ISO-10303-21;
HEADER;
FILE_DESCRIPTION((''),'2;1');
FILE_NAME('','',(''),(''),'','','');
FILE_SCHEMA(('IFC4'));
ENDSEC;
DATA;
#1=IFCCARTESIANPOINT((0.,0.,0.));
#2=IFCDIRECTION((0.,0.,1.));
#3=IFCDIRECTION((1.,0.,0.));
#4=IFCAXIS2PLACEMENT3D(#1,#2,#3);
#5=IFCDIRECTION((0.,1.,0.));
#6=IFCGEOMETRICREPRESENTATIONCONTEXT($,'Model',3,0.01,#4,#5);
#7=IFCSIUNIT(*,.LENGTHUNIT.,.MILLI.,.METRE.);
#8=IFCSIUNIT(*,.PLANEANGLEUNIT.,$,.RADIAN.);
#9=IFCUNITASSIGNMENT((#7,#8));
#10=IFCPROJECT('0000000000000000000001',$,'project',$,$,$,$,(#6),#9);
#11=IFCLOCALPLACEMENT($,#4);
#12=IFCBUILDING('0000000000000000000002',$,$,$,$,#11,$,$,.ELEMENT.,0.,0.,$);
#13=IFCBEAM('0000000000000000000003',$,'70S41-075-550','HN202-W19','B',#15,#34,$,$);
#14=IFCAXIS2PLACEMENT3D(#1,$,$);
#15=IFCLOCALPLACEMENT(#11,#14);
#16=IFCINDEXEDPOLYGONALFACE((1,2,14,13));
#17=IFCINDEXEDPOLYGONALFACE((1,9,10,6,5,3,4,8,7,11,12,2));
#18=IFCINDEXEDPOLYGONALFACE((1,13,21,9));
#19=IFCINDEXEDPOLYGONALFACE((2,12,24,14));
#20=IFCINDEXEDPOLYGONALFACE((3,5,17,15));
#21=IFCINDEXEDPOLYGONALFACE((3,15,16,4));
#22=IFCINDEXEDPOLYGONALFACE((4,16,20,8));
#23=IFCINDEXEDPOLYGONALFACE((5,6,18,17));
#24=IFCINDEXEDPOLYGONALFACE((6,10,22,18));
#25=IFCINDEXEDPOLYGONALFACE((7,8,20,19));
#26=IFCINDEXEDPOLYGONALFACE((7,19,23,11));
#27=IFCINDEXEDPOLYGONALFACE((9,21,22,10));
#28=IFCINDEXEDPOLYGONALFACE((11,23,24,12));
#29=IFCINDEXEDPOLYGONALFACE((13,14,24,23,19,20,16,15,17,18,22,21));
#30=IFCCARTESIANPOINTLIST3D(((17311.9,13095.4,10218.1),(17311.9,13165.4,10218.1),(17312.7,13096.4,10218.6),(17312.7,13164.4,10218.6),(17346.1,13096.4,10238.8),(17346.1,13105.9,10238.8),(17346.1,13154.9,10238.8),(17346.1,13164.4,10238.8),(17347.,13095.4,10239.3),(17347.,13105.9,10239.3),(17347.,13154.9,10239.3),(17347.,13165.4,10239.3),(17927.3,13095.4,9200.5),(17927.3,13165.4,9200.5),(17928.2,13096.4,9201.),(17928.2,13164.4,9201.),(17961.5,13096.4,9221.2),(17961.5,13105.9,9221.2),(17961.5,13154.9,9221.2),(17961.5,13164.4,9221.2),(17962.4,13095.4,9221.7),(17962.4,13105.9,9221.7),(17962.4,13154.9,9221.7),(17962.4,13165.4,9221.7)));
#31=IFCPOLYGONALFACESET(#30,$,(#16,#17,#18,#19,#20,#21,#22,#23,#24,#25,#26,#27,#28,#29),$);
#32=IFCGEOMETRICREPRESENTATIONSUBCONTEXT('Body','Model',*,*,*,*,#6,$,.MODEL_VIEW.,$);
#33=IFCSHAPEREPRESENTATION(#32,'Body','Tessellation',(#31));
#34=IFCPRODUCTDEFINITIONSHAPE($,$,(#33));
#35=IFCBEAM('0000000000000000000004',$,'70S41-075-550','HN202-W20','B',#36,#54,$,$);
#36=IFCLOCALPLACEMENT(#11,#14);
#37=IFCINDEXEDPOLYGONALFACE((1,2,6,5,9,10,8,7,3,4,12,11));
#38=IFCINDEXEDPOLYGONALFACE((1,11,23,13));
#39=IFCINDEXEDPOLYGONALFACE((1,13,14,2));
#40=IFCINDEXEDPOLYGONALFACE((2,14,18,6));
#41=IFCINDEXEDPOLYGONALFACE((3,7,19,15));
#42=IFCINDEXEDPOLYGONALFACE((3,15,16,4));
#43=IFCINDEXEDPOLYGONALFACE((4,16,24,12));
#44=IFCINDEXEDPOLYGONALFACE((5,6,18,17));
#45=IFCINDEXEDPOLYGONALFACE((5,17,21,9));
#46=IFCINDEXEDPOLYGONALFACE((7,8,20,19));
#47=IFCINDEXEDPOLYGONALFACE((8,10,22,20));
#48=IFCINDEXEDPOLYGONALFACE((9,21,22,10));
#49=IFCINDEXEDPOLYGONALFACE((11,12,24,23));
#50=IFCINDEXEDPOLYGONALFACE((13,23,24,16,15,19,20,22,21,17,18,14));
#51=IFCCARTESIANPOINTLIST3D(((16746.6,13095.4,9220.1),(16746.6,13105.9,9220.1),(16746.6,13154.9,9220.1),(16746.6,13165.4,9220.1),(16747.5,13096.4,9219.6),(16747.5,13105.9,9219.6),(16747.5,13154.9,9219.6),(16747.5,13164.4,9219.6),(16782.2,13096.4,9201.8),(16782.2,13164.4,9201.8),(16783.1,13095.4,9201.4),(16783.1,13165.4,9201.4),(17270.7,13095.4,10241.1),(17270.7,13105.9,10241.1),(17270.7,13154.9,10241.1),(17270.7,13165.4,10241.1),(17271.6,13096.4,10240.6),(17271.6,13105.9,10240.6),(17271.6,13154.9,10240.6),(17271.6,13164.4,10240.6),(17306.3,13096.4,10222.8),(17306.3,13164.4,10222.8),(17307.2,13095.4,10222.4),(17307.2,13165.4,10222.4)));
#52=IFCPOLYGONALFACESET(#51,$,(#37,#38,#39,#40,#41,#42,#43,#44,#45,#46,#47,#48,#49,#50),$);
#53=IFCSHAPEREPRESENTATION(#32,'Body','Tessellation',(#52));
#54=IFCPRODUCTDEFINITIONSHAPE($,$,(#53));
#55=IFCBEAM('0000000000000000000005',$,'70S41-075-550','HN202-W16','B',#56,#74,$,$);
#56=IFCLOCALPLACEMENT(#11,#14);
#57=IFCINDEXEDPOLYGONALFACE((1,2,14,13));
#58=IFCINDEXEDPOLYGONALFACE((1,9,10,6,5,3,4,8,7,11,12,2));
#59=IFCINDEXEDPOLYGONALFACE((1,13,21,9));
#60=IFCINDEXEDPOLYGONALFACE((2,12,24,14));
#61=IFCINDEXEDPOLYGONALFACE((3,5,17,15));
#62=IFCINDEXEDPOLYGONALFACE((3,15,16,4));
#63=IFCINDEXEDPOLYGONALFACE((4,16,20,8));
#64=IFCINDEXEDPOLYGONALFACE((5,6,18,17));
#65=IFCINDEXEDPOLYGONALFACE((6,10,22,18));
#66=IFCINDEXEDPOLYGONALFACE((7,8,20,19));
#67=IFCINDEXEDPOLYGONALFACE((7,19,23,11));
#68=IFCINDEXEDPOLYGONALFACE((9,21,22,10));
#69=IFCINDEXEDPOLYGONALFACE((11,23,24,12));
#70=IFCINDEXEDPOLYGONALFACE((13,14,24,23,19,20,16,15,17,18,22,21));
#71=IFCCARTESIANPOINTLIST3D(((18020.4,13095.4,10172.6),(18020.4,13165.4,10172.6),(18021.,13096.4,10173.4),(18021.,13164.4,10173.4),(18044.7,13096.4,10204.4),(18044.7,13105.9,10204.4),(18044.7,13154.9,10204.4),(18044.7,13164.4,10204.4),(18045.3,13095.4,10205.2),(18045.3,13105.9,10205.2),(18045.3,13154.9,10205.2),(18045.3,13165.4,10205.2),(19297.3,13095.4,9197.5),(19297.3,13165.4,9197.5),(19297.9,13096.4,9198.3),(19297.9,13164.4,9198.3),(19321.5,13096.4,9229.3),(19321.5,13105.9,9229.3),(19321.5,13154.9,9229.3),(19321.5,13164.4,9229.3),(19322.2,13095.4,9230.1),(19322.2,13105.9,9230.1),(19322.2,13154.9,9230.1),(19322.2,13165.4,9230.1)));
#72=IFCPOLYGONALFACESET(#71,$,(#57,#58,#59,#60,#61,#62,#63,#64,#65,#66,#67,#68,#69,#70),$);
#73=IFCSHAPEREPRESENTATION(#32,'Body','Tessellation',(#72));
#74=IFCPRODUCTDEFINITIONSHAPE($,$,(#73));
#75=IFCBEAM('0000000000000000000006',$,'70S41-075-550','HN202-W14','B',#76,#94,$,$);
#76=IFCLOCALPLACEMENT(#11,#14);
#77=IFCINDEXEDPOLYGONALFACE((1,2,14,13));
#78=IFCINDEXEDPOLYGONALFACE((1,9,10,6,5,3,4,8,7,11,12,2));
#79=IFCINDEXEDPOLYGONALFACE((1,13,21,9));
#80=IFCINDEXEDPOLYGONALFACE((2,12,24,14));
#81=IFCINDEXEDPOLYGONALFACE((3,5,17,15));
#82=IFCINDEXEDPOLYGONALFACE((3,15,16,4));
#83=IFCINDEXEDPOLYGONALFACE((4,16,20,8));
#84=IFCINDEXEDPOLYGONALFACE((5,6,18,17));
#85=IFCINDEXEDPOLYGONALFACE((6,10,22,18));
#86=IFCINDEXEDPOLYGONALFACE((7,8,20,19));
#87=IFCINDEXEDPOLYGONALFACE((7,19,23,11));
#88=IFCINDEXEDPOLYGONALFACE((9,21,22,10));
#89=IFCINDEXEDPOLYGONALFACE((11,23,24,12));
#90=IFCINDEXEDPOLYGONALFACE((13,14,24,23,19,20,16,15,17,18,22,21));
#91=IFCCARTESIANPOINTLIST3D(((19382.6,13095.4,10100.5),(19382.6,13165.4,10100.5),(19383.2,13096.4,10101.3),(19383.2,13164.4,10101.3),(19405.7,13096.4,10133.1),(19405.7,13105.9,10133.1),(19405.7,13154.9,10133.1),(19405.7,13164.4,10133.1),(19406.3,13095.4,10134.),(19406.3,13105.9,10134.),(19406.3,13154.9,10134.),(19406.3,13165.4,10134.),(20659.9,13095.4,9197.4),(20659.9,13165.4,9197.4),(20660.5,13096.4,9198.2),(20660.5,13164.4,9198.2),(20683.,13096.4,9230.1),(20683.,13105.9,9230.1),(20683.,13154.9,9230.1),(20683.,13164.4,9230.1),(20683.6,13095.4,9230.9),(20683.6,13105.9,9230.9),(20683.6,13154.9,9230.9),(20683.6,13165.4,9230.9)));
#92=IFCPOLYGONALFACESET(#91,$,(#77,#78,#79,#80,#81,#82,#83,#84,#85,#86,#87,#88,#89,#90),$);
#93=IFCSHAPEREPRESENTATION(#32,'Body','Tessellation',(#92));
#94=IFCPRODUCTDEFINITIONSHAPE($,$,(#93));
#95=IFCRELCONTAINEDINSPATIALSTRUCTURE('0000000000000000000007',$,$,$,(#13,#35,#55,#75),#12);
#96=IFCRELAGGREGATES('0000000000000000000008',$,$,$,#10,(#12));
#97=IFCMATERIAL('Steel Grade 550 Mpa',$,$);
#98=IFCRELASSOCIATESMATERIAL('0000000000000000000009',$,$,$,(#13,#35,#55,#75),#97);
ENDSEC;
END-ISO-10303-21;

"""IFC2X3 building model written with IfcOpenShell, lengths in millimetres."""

from ifc_helpers import new_model, si_unit, direction, frame, origin, origin_with_axes, origin_2d_with_axis, place, context, subcontext, project, spatial, c_section, extrude, source, transform, mapped, material, element, save


model = new_model("IFC2X3")

# Units and contexts
model_context = context("Model", 3, precision=0.01, world=origin_with_axes(), true_north=direction((0.0, 1.0, 0.0)))
body_context = subcontext(model_context, "Body", "Model", "MODEL_VIEW")
ifc_project = project(units=[si_unit("LENGTHUNIT", "METRE", prefix="MILLI"), si_unit("PLANEANGLEUNIT", "RADIAN")], contexts=[model_context])

# Building
building_placement = place(None, origin_with_axes())
building = spatial("IfcBuilding", under=ifc_project, at=building_placement, CompositionType="ELEMENT", ElevationOfRefHeight=0.0, ElevationOfTerrain=0.0)

# Shared definitions
ifc_material = material(Name="Steel Grade 550 Mpa")

# Beams
shared_shape_1 = source(origin(), body_context, "Body", "SweptSolid", [
    extrude(c_section(Depth=70.0, Width=41.0, WallThickness=1.0, Girth=10.5, at=origin_2d_with_axis()), origin_with_axes(), (0.0, 0.0, 1.0), 1189.2),
])
beam_1_placement = place(None, frame((17944.9, 13130.4, 9211.1), z_axis=(-0.517517, 0.0, 0.855673), x_axis=(0.855673, 0.0, 0.517517)))
element("IfcBeam", 1, at=beam_1_placement, inside=building, material=ifc_material, Name="70S41-075-550", Description="HN202-W19", ObjectType="B", context=body_context, shape_type="MappedRepresentation", body=[
    mapped(shared_shape_1, transform((0.0, 0.0, 0.0), scale=1.0)),
])
shared_shape_2 = source(origin(), body_context, "Body", "SweptSolid", [
    extrude(c_section(Depth=70.0, Width=41.0, WallThickness=1.0, Girth=10.5, at=origin_2d_with_axis()), origin_with_axes(), (0.0, 0.0, 1.0), 1147.7),
])
beam_2_placement = place(None, frame((17289.0, 13130.4, 10231.7), z_axis=(-0.456666, 0.0, -0.889638), x_axis=(-0.889638, 0.0, 0.456666)))
element("IfcBeam", 2, at=beam_2_placement, inside=building, material=ifc_material, Name="70S41-075-550", Description="HN202-W20", ObjectType="B", context=body_context, shape_type="MappedRepresentation", body=[
    mapped(shared_shape_2, transform((0.0, 0.0, 0.0), scale=1.0)),
])
shared_shape_3 = source(origin(), body_context, "Body", "SweptSolid", [
    extrude(c_section(Depth=70.0, Width=41.0, WallThickness=1.0, Girth=10.5, at=origin_2d_with_axis()), origin_with_axes(), (0.0, 0.0, 1.0), 1606.6),
])
beam_3_placement = place(None, frame((19309.7, 13130.4, 9213.8), z_axis=(-0.794756, 0.0, 0.606929), x_axis=(0.606929, 0.0, 0.794756)))
element("IfcBeam", 3, at=beam_3_placement, inside=building, material=ifc_material, Name="70S41-075-550", Description="HN202-W16", ObjectType="B", context=body_context, shape_type="MappedRepresentation", body=[
    mapped(shared_shape_3, transform((0.0, 0.0, 0.0), scale=1.0)),
])
shared_shape_4 = source(origin(), body_context, "Body", "SweptSolid", [
    extrude(c_section(Depth=70.0, Width=41.0, WallThickness=1.0, Girth=10.5, at=origin_2d_with_axis()), origin_with_axes(), (0.0, 0.0, 1.0), 1564.3),
])
beam_4_placement = place(None, frame((20671.8, 13130.4, 9214.1), z_axis=(-0.816539, 0.0, 0.57729), x_axis=(0.57729, 0.0, 0.816539)))
element("IfcBeam", 4, at=beam_4_placement, inside=building, material=ifc_material, Name="70S41-075-550", Description="HN202-W14", ObjectType="B", context=body_context, shape_type="MappedRepresentation", body=[
    mapped(shared_shape_4, transform((0.0, 0.0, 0.0), scale=1.0)),
])

save(model, "model.ifc")
